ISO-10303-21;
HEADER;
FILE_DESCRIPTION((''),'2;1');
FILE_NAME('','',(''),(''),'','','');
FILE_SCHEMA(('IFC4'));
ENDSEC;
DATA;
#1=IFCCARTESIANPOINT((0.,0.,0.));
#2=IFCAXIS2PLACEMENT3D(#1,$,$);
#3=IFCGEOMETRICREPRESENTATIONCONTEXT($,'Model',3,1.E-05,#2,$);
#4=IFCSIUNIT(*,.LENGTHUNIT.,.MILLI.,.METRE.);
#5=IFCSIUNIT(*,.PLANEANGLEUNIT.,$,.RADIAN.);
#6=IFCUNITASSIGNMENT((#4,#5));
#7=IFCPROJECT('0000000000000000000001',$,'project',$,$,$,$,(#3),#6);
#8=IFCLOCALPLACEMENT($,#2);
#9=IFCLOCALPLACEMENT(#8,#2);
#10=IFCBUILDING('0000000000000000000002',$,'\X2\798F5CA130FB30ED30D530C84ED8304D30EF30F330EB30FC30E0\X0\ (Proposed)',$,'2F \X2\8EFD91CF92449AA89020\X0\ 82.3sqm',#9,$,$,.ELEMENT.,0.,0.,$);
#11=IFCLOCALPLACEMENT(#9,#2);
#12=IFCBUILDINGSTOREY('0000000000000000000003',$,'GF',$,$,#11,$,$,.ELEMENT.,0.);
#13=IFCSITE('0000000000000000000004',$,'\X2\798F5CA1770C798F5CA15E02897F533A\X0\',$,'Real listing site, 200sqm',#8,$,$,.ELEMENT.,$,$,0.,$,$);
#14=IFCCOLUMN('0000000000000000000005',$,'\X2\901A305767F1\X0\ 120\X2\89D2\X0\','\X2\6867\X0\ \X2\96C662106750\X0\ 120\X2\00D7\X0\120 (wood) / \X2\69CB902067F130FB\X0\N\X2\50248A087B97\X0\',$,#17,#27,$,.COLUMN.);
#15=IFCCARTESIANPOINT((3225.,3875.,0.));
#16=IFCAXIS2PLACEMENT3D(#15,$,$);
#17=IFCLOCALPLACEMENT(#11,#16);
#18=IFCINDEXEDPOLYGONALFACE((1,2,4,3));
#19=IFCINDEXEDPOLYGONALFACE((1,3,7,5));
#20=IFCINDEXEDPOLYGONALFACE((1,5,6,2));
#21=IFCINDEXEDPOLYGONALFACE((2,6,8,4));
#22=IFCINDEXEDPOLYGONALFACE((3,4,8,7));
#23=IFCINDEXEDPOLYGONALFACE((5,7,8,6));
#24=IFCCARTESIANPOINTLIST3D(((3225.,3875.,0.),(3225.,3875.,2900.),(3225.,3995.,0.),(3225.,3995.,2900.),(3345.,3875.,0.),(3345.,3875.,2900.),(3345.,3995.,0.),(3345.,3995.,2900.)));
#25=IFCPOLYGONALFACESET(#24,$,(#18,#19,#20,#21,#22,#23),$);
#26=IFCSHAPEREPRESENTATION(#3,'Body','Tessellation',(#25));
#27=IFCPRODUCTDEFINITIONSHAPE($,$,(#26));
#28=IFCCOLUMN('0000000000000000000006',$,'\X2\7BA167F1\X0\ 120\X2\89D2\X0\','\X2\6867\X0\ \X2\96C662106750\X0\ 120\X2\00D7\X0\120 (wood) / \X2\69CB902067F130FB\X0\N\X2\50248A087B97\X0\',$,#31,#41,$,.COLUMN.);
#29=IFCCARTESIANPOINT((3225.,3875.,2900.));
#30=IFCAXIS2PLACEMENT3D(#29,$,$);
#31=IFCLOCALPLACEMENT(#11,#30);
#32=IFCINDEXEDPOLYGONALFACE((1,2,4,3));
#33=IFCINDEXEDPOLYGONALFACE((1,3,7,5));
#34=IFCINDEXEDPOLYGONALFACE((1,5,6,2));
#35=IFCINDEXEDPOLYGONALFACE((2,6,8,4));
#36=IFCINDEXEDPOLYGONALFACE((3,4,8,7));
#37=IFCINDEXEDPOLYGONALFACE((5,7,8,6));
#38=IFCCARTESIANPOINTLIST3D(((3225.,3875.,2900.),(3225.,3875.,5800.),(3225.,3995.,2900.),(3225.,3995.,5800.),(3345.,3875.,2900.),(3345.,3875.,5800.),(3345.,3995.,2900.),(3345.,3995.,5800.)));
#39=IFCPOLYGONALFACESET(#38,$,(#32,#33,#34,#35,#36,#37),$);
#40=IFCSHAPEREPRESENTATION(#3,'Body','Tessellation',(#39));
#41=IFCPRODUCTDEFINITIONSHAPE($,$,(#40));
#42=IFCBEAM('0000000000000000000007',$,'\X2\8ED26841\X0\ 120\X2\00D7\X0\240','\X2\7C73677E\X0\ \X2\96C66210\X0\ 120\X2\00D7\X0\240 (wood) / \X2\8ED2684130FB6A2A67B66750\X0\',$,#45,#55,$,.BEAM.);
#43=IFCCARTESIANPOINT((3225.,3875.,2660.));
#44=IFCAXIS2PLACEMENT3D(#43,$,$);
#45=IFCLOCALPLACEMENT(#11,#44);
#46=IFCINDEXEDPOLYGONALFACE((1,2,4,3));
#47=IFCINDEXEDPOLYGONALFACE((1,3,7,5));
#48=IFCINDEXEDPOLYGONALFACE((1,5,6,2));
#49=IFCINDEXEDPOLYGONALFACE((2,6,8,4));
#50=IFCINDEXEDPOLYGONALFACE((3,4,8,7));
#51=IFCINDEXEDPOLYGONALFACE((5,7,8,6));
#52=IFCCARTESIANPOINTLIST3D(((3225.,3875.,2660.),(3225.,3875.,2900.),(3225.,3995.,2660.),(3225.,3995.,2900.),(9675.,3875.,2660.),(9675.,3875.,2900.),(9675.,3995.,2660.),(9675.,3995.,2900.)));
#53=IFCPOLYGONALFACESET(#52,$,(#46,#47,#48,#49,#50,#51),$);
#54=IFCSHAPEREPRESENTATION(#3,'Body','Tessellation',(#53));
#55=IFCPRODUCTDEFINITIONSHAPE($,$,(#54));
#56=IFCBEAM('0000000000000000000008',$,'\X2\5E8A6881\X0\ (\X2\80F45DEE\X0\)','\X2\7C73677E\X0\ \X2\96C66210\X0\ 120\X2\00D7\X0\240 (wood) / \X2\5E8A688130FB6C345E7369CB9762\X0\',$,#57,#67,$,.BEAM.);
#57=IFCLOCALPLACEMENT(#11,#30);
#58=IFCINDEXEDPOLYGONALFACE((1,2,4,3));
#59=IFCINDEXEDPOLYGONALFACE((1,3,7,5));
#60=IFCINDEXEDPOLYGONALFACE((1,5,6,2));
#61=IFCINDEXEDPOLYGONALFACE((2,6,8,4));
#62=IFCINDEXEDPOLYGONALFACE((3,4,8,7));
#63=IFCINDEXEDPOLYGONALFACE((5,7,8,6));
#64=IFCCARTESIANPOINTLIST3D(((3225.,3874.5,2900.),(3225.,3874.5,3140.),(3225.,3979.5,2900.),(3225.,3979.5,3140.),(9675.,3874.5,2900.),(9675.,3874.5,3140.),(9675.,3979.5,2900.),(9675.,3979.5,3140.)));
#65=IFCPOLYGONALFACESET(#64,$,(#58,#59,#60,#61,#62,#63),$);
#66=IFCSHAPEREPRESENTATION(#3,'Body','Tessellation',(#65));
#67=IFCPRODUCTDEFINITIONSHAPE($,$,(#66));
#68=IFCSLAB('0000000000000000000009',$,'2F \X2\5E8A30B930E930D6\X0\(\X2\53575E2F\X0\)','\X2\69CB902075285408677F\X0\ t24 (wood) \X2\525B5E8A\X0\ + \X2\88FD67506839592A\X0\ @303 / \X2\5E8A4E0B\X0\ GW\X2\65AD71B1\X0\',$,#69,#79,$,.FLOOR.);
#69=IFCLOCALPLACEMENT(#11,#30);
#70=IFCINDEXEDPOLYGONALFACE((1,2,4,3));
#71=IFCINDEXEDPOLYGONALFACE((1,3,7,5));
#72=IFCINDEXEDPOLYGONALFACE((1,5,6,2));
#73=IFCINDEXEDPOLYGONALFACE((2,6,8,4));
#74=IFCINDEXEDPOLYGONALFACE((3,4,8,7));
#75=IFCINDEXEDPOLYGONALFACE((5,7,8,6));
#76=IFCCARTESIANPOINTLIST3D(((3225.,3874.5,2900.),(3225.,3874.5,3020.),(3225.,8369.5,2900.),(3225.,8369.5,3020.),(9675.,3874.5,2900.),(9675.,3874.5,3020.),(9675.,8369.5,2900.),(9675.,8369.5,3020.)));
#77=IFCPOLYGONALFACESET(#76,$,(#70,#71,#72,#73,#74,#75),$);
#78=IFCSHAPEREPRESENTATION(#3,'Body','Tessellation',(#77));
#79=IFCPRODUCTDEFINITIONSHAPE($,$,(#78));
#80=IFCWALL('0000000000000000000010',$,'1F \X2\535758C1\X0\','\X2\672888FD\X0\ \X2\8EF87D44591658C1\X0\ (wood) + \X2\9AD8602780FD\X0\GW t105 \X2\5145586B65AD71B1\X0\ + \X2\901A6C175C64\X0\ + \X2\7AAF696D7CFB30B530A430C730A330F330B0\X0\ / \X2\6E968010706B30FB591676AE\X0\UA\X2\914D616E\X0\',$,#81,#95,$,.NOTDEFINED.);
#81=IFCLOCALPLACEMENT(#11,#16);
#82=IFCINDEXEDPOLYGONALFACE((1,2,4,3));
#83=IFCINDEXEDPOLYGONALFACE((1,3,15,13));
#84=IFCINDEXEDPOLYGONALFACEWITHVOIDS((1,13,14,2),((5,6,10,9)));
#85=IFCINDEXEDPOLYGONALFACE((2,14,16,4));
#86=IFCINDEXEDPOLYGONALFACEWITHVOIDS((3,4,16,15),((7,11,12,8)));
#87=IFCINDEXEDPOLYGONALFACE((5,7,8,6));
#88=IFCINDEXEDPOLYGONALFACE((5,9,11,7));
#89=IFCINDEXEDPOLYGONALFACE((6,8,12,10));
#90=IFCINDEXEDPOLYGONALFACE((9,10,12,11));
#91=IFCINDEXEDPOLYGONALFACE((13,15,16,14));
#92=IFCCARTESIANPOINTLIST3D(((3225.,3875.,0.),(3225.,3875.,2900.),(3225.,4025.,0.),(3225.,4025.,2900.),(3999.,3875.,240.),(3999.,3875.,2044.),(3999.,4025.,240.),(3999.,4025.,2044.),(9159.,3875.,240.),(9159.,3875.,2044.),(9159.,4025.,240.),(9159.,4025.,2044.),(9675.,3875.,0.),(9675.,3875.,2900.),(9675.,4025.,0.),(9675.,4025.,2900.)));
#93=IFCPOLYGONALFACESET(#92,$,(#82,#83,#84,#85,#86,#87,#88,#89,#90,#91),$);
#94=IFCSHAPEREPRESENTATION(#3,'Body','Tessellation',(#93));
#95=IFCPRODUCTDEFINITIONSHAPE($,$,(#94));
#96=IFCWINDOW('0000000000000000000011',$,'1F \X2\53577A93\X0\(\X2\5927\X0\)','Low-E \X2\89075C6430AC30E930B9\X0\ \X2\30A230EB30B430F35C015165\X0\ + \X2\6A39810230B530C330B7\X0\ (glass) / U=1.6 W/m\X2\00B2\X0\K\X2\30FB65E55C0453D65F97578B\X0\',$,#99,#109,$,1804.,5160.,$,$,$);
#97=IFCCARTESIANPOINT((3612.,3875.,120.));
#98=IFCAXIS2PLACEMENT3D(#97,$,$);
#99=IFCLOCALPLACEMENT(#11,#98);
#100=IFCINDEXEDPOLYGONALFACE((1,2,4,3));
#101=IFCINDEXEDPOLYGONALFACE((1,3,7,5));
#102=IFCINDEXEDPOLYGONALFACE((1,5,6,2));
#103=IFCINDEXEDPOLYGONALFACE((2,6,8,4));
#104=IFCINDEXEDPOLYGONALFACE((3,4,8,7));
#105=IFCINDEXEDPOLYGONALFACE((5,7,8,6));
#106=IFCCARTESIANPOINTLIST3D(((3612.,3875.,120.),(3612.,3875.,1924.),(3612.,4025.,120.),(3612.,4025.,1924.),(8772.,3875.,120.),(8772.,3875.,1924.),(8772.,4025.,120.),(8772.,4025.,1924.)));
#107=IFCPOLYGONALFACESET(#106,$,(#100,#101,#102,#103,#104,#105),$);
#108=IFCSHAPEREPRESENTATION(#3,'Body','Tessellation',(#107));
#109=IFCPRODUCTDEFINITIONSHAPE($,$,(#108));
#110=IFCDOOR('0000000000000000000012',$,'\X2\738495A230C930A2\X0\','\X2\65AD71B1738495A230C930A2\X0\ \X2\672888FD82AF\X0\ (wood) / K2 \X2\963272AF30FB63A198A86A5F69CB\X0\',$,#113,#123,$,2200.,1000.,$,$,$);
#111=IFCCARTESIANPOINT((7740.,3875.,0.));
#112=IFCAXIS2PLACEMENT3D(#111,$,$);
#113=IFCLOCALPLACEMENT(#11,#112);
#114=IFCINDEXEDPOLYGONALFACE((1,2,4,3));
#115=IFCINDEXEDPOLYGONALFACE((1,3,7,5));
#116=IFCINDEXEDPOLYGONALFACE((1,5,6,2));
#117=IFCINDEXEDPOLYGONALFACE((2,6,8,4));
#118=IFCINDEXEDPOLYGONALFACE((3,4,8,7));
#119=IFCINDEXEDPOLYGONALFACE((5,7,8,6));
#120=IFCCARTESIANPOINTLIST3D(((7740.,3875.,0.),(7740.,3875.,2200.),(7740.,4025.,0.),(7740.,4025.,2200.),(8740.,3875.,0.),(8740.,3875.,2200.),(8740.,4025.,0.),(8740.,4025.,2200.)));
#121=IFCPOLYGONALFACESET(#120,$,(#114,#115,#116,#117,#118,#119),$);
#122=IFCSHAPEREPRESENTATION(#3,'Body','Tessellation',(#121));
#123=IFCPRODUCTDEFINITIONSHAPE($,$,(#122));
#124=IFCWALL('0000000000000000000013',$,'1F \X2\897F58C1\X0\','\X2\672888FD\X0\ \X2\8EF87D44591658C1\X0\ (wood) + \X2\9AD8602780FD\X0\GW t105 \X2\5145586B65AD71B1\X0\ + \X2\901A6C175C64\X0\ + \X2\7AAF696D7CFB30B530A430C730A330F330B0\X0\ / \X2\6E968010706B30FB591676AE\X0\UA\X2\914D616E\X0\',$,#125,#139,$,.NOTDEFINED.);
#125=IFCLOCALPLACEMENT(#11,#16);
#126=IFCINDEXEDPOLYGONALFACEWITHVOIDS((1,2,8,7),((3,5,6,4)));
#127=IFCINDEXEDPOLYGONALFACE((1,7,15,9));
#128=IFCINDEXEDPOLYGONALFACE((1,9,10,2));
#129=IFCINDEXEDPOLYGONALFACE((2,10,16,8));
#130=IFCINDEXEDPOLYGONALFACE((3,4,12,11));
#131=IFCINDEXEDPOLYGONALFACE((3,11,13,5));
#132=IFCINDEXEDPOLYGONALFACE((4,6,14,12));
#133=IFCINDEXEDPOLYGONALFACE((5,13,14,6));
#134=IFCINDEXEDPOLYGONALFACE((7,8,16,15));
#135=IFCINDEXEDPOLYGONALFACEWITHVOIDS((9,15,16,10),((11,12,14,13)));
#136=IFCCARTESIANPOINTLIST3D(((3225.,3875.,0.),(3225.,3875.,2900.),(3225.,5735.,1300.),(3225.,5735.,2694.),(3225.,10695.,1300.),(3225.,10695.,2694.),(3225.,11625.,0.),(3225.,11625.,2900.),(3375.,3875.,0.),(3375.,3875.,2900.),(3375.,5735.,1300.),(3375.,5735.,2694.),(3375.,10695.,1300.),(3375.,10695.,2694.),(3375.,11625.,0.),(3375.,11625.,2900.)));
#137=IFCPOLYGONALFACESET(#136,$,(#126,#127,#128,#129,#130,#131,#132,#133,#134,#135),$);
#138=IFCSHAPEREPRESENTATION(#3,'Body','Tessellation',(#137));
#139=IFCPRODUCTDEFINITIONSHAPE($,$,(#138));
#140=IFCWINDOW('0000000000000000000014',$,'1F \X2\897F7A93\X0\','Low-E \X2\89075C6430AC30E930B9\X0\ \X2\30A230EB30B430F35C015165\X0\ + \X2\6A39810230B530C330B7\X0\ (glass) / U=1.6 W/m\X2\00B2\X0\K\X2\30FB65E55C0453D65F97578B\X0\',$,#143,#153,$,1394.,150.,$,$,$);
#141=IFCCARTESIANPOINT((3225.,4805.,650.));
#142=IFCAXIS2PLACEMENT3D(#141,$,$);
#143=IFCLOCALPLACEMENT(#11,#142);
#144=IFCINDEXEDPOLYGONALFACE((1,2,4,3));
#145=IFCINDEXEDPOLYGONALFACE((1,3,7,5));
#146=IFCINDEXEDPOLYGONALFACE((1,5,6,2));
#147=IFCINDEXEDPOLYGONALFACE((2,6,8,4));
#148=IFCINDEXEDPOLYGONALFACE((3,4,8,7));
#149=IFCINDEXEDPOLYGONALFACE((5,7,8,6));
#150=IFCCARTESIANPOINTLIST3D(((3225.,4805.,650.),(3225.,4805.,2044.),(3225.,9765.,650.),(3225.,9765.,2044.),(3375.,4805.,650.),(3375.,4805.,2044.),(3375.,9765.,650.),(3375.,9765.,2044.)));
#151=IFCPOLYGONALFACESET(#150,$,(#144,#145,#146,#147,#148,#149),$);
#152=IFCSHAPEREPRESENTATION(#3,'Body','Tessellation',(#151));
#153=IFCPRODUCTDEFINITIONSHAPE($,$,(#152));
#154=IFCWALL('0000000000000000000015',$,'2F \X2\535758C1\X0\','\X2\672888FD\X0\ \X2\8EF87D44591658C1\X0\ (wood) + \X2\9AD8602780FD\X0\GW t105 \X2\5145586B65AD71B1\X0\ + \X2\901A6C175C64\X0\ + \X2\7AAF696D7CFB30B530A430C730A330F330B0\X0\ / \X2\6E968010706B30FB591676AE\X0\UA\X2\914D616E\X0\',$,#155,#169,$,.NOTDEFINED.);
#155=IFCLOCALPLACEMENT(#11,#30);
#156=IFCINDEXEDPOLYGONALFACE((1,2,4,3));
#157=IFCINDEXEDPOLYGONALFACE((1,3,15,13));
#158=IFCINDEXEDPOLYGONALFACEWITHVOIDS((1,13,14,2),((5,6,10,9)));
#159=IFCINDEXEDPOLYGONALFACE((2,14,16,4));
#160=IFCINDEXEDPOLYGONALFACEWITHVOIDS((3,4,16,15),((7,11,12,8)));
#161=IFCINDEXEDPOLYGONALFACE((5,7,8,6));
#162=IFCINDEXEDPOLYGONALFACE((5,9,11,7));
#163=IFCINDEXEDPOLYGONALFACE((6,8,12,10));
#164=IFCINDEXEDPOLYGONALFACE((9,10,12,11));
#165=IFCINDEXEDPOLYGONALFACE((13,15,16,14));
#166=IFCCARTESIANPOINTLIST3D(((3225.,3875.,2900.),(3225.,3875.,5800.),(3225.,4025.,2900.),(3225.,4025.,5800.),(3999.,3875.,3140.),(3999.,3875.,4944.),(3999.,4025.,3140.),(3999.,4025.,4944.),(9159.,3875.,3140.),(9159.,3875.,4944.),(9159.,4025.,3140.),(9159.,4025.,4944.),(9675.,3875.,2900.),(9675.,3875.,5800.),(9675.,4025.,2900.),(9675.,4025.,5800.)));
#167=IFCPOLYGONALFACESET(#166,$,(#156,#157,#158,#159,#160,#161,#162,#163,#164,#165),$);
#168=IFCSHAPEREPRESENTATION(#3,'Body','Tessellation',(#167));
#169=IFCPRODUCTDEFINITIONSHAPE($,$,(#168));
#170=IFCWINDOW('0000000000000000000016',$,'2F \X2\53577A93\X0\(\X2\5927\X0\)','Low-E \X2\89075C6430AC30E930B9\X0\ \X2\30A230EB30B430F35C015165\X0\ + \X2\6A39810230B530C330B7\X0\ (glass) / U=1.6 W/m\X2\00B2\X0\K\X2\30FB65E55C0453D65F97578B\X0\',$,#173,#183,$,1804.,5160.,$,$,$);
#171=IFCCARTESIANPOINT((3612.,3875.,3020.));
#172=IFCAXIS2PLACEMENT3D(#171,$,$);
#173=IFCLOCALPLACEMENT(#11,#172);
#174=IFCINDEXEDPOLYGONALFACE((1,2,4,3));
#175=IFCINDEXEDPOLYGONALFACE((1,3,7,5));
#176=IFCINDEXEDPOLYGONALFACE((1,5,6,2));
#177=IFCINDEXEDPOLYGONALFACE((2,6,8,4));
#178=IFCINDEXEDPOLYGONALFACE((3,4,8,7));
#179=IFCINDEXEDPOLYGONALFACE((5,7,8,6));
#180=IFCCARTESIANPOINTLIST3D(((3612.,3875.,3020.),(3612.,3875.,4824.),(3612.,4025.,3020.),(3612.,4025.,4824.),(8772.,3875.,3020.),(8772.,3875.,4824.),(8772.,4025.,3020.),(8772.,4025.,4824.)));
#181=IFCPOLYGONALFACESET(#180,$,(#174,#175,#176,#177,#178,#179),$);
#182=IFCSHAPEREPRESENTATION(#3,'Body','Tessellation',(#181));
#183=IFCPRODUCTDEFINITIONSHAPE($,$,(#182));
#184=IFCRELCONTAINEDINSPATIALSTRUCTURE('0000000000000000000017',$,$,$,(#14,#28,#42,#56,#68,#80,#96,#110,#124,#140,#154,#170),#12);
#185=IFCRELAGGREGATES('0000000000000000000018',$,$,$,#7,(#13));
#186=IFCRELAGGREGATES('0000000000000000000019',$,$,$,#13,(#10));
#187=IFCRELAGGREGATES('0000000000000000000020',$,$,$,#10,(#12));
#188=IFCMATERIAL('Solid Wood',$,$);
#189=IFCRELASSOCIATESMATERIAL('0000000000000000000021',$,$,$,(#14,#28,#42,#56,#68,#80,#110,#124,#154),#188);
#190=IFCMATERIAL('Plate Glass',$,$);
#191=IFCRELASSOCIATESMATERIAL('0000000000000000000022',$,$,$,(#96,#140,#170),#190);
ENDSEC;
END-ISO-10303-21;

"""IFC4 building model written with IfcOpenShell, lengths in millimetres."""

from ifc_helpers import new_model, si_unit, frame, frame_2d, origin, place, context, project, spatial, rectangle, extrude, material, element, fill, save


model = new_model("IFC4")

# Units and contexts
model_context = context("Model", 3, precision=1e-05, world=origin())
ifc_project = project(units=[si_unit("LENGTHUNIT", "METRE", prefix="MILLI"), si_unit("PLANEANGLEUNIT", "RADIAN")], contexts=[model_context])

# Site, building, storey
site_placement = place(None, origin())
site = spatial("IfcSite", under=ifc_project, at=site_placement, Name="福岡県福岡市西区", ObjectType="Real listing site, 200sqm", CompositionType="ELEMENT", RefElevation=0.0)
building_placement = place(site_placement, origin())
building = spatial("IfcBuilding", under=site, at=building_placement, Name="福岡・ロフト付きワンルーム (Proposed)", ObjectType="2F 軽量鉄骨造 82.3sqm", CompositionType="ELEMENT", ElevationOfRefHeight=0.0, ElevationOfTerrain=0.0)
storey_placement = place(building_placement, origin())
storey = spatial("IfcBuildingStorey", under=building, at=storey_placement, Name="GF", CompositionType="ELEMENT", Elevation=0.0)

# Columns
ifc_material_1 = material(Name="Solid Wood")
column_1_placement = place(storey_placement, frame((3225.0, 3875.0, 0.0)))
element("IfcColumn", 1, at=column_1_placement, inside=storey, material=ifc_material_1, Name="通し柱 120角", Description="桧 集成材 120×120 (wood) / 構造柱・N値計算", PredefinedType="COLUMN", context=model_context, shape_type="SweptSolid", body=[
    extrude(rectangle(XDim=120.0, YDim=120.0, at=frame_2d((60.0, 60.0))), frame((3225.0, 3875.0, 0.0)), (0.0, 0.0, 1.0), 2900.0),
])
column_2_placement = place(storey_placement, frame((3225.0, 3875.0, 2900.0)))
element("IfcColumn", 2, at=column_2_placement, inside=storey, material=ifc_material_1, Name="管柱 120角", Description="桧 集成材 120×120 (wood) / 構造柱・N値計算", PredefinedType="COLUMN", context=model_context, shape_type="SweptSolid", body=[
    extrude(rectangle(XDim=120.0, YDim=120.0, at=frame_2d((60.0, 60.0))), frame((3225.0, 3875.0, 2900.0)), (0.0, 0.0, 1.0), 2900.0),
])

# Beams
beam_1_placement = place(storey_placement, frame((3225.0, 3875.0, 2660.0)))
element("IfcBeam", 3, at=beam_1_placement, inside=storey, material=ifc_material_1, Name="軒桁 120×240", Description="米松 集成 120×240 (wood) / 軒桁・横架材", PredefinedType="BEAM", context=model_context, shape_type="SweptSolid", body=[
    extrude(rectangle(XDim=6450.0, YDim=120.0, at=frame_2d((3225.0, 60.0))), frame((3225.0, 3875.0, 2660.0)), (0.0, 0.0, 1.0), 240.0),
])
beam_2_placement = place(storey_placement, frame((3225.0, 3875.0, 2900.0)))
element("IfcBeam", 4, at=beam_2_placement, inside=storey, material=ifc_material_1, Name="床梁 (胴差)", Description="米松 集成 120×240 (wood) / 床梁・水平構面", PredefinedType="BEAM", context=model_context, shape_type="SweptSolid", body=[
    extrude(rectangle(XDim=6450.0, YDim=105.0, at=frame_2d((3225.0, 52.0))), frame((3225.0, 3875.0, 2900.0)), (0.0, 0.0, 1.0), 240.0),
])

# Slab
slab_1_placement = place(storey_placement, frame((3225.0, 3875.0, 2900.0)))
element("IfcSlab", 5, at=slab_1_placement, inside=storey, material=ifc_material_1, Name="2F 床スラブ(南帯)", Description="構造用合板 t24 (wood) 剛床 + 製材根太 @303 / 床下 GW断熱", PredefinedType="FLOOR", context=model_context, shape_type="SweptSolid", body=[
    extrude(rectangle(XDim=6450.0, YDim=4495.0, at=frame_2d((3225.0, 2247.0))), frame((3225.0, 3875.0, 2900.0)), (0.0, 0.0, 1.0), 120.0),
])

# Wall, openings, window, door
wall_1_placement = place(storey_placement, frame((3225.0, 3875.0, 0.0)))
wall_1 = element("IfcWall", 6, at=wall_1_placement, inside=storey, material=ifc_material_1, Name="1F 南壁", Description="木製 軸組外壁 (wood) + 高性能GW t105 充填断熱 + 通気層 + 窯業系サイディング / 準耐火・外皮UA配慮", PredefinedType="NOTDEFINED", context=model_context, shape_type="SweptSolid", body=[
    extrude(rectangle(XDim=6450.0, YDim=150.0, at=frame_2d((3225.0, 75.0))), frame((3225.0, 3875.0, 0.0)), (0.0, 0.0, 1.0), 2900.0),
])
opening_1_placement = place(storey_placement, frame((3612.0, 3875.0, 120.0)))
opening_1 = element("IfcOpeningElement", 7, at=opening_1_placement, cuts=wall_1, PredefinedType="NOTDEFINED", context=model_context, shape_type="SweptSolid", body=[
    extrude(rectangle(XDim=5160.0, YDim=150.0, at=frame_2d((2580.0, 75.0))), frame((3612.0, 3875.0, 120.0)), (0.0, 0.0, 1.0), 1804.0),
])
opening_2_placement = place(storey_placement, frame((7740.0, 3875.0, 0.0)))
opening_2 = element("IfcOpeningElement", 8, at=opening_2_placement, cuts=wall_1, PredefinedType="NOTDEFINED", context=model_context, shape_type="SweptSolid", body=[
    extrude(rectangle(XDim=1000.0, YDim=150.0, at=frame_2d((500.0, 75.0))), frame((7740.0, 3875.0, 0.0)), (0.0, 0.0, 1.0), 2200.0),
])
ifc_material_2 = material(Name="Plate Glass")
window_1_placement = place(storey_placement, frame((3612.0, 3875.0, 120.0)))
window_1 = element("IfcWindow", 9, at=window_1_placement, inside=storey, material=ifc_material_2, Name="1F 南窓(大)", Description="Low-E 複層ガラス アルゴン封入 + 樹脂サッシ (glass) / U=1.6 W/m²K・日射取得型", OverallHeight=1804.0, OverallWidth=5160.0, context=model_context, shape_type="SweptSolid", body=[
    extrude(rectangle(XDim=5160.0, YDim=150.0, at=frame_2d((2580.0, 75.0))), frame((3612.0, 3875.0, 120.0)), (0.0, 0.0, 1.0), 1804.0),
])
fill(opening_1, window_1)
door_placement = place(storey_placement, frame((7740.0, 3875.0, 0.0)))
door = element("IfcDoor", 10, at=door_placement, inside=storey, material=ifc_material_1, Name="玄関ドア", Description="断熱玄関ドア 木製芯 (wood) / K2 防犯・採風機構", OverallHeight=2200.0, OverallWidth=1000.0, context=model_context, shape_type="SweptSolid", body=[
    extrude(rectangle(XDim=1000.0, YDim=150.0, at=frame_2d((500.0, 75.0))), frame((7740.0, 3875.0, 0.0)), (0.0, 0.0, 1.0), 2200.0),
])
fill(opening_2, door)

# Walls, openings, windows
wall_2_placement = place(storey_placement, frame((3225.0, 3875.0, 0.0)))
wall_2 = element("IfcWall", 11, at=wall_2_placement, inside=storey, material=ifc_material_1, Name="1F 西壁", Description="木製 軸組外壁 (wood) + 高性能GW t105 充填断熱 + 通気層 + 窯業系サイディング / 準耐火・外皮UA配慮", PredefinedType="NOTDEFINED", context=model_context, shape_type="SweptSolid", body=[
    extrude(rectangle(XDim=150.0, YDim=7750.0, at=frame_2d((75.0, 3875.0))), frame((3225.0, 3875.0, 0.0)), (0.0, 0.0, 1.0), 2900.0),
])
opening_3_placement = place(storey_placement, frame((3225.0, 4805.0, 650.0)))
opening_3 = element("IfcOpeningElement", 12, at=opening_3_placement, cuts=wall_2, PredefinedType="NOTDEFINED", context=model_context, shape_type="SweptSolid", body=[
    extrude(rectangle(XDim=150.0, YDim=4960.0, at=frame_2d((75.0, 2480.0))), frame((3225.0, 4805.0, 650.0)), (0.0, 0.0, 1.0), 1394.0),
])
window_2_placement = place(storey_placement, frame((3225.0, 4805.0, 650.0)))
window_2 = element("IfcWindow", 13, at=window_2_placement, inside=storey, material=ifc_material_2, Name="1F 西窓", Description="Low-E 複層ガラス アルゴン封入 + 樹脂サッシ (glass) / U=1.6 W/m²K・日射取得型", OverallHeight=1394.0, OverallWidth=150.0, context=model_context, shape_type="SweptSolid", body=[
    extrude(rectangle(XDim=150.0, YDim=4960.0, at=frame_2d((75.0, 2480.0))), frame((3225.0, 4805.0, 650.0)), (0.0, 0.0, 1.0), 1394.0),
])
fill(opening_3, window_2)
wall_3_placement = place(storey_placement, frame((3225.0, 3875.0, 2900.0)))
wall_3 = element("IfcWall", 14, at=wall_3_placement, inside=storey, material=ifc_material_1, Name="2F 南壁", Description="木製 軸組外壁 (wood) + 高性能GW t105 充填断熱 + 通気層 + 窯業系サイディング / 準耐火・外皮UA配慮", PredefinedType="NOTDEFINED", context=model_context, shape_type="SweptSolid", body=[
    extrude(rectangle(XDim=6450.0, YDim=150.0, at=frame_2d((3225.0, 75.0))), frame((3225.0, 3875.0, 2900.0)), (0.0, 0.0, 1.0), 2900.0),
])
opening_4_placement = place(storey_placement, frame((3612.0, 3875.0, 3020.0)))
opening_4 = element("IfcOpeningElement", 15, at=opening_4_placement, cuts=wall_3, PredefinedType="NOTDEFINED", context=model_context, shape_type="SweptSolid", body=[
    extrude(rectangle(XDim=5160.0, YDim=150.0, at=frame_2d((2580.0, 75.0))), frame((3612.0, 3875.0, 3020.0)), (0.0, 0.0, 1.0), 1804.0),
])
window_3_placement = place(storey_placement, frame((3612.0, 3875.0, 3020.0)))
window_3 = element("IfcWindow", 16, at=window_3_placement, inside=storey, material=ifc_material_2, Name="2F 南窓(大)", Description="Low-E 複層ガラス アルゴン封入 + 樹脂サッシ (glass) / U=1.6 W/m²K・日射取得型", OverallHeight=1804.0, OverallWidth=5160.0, context=model_context, shape_type="SweptSolid", body=[
    extrude(rectangle(XDim=5160.0, YDim=150.0, at=frame_2d((2580.0, 75.0))), frame((3612.0, 3875.0, 3020.0)), (0.0, 0.0, 1.0), 1804.0),
])
fill(opening_4, window_3)

save(model, "model.ifc")
